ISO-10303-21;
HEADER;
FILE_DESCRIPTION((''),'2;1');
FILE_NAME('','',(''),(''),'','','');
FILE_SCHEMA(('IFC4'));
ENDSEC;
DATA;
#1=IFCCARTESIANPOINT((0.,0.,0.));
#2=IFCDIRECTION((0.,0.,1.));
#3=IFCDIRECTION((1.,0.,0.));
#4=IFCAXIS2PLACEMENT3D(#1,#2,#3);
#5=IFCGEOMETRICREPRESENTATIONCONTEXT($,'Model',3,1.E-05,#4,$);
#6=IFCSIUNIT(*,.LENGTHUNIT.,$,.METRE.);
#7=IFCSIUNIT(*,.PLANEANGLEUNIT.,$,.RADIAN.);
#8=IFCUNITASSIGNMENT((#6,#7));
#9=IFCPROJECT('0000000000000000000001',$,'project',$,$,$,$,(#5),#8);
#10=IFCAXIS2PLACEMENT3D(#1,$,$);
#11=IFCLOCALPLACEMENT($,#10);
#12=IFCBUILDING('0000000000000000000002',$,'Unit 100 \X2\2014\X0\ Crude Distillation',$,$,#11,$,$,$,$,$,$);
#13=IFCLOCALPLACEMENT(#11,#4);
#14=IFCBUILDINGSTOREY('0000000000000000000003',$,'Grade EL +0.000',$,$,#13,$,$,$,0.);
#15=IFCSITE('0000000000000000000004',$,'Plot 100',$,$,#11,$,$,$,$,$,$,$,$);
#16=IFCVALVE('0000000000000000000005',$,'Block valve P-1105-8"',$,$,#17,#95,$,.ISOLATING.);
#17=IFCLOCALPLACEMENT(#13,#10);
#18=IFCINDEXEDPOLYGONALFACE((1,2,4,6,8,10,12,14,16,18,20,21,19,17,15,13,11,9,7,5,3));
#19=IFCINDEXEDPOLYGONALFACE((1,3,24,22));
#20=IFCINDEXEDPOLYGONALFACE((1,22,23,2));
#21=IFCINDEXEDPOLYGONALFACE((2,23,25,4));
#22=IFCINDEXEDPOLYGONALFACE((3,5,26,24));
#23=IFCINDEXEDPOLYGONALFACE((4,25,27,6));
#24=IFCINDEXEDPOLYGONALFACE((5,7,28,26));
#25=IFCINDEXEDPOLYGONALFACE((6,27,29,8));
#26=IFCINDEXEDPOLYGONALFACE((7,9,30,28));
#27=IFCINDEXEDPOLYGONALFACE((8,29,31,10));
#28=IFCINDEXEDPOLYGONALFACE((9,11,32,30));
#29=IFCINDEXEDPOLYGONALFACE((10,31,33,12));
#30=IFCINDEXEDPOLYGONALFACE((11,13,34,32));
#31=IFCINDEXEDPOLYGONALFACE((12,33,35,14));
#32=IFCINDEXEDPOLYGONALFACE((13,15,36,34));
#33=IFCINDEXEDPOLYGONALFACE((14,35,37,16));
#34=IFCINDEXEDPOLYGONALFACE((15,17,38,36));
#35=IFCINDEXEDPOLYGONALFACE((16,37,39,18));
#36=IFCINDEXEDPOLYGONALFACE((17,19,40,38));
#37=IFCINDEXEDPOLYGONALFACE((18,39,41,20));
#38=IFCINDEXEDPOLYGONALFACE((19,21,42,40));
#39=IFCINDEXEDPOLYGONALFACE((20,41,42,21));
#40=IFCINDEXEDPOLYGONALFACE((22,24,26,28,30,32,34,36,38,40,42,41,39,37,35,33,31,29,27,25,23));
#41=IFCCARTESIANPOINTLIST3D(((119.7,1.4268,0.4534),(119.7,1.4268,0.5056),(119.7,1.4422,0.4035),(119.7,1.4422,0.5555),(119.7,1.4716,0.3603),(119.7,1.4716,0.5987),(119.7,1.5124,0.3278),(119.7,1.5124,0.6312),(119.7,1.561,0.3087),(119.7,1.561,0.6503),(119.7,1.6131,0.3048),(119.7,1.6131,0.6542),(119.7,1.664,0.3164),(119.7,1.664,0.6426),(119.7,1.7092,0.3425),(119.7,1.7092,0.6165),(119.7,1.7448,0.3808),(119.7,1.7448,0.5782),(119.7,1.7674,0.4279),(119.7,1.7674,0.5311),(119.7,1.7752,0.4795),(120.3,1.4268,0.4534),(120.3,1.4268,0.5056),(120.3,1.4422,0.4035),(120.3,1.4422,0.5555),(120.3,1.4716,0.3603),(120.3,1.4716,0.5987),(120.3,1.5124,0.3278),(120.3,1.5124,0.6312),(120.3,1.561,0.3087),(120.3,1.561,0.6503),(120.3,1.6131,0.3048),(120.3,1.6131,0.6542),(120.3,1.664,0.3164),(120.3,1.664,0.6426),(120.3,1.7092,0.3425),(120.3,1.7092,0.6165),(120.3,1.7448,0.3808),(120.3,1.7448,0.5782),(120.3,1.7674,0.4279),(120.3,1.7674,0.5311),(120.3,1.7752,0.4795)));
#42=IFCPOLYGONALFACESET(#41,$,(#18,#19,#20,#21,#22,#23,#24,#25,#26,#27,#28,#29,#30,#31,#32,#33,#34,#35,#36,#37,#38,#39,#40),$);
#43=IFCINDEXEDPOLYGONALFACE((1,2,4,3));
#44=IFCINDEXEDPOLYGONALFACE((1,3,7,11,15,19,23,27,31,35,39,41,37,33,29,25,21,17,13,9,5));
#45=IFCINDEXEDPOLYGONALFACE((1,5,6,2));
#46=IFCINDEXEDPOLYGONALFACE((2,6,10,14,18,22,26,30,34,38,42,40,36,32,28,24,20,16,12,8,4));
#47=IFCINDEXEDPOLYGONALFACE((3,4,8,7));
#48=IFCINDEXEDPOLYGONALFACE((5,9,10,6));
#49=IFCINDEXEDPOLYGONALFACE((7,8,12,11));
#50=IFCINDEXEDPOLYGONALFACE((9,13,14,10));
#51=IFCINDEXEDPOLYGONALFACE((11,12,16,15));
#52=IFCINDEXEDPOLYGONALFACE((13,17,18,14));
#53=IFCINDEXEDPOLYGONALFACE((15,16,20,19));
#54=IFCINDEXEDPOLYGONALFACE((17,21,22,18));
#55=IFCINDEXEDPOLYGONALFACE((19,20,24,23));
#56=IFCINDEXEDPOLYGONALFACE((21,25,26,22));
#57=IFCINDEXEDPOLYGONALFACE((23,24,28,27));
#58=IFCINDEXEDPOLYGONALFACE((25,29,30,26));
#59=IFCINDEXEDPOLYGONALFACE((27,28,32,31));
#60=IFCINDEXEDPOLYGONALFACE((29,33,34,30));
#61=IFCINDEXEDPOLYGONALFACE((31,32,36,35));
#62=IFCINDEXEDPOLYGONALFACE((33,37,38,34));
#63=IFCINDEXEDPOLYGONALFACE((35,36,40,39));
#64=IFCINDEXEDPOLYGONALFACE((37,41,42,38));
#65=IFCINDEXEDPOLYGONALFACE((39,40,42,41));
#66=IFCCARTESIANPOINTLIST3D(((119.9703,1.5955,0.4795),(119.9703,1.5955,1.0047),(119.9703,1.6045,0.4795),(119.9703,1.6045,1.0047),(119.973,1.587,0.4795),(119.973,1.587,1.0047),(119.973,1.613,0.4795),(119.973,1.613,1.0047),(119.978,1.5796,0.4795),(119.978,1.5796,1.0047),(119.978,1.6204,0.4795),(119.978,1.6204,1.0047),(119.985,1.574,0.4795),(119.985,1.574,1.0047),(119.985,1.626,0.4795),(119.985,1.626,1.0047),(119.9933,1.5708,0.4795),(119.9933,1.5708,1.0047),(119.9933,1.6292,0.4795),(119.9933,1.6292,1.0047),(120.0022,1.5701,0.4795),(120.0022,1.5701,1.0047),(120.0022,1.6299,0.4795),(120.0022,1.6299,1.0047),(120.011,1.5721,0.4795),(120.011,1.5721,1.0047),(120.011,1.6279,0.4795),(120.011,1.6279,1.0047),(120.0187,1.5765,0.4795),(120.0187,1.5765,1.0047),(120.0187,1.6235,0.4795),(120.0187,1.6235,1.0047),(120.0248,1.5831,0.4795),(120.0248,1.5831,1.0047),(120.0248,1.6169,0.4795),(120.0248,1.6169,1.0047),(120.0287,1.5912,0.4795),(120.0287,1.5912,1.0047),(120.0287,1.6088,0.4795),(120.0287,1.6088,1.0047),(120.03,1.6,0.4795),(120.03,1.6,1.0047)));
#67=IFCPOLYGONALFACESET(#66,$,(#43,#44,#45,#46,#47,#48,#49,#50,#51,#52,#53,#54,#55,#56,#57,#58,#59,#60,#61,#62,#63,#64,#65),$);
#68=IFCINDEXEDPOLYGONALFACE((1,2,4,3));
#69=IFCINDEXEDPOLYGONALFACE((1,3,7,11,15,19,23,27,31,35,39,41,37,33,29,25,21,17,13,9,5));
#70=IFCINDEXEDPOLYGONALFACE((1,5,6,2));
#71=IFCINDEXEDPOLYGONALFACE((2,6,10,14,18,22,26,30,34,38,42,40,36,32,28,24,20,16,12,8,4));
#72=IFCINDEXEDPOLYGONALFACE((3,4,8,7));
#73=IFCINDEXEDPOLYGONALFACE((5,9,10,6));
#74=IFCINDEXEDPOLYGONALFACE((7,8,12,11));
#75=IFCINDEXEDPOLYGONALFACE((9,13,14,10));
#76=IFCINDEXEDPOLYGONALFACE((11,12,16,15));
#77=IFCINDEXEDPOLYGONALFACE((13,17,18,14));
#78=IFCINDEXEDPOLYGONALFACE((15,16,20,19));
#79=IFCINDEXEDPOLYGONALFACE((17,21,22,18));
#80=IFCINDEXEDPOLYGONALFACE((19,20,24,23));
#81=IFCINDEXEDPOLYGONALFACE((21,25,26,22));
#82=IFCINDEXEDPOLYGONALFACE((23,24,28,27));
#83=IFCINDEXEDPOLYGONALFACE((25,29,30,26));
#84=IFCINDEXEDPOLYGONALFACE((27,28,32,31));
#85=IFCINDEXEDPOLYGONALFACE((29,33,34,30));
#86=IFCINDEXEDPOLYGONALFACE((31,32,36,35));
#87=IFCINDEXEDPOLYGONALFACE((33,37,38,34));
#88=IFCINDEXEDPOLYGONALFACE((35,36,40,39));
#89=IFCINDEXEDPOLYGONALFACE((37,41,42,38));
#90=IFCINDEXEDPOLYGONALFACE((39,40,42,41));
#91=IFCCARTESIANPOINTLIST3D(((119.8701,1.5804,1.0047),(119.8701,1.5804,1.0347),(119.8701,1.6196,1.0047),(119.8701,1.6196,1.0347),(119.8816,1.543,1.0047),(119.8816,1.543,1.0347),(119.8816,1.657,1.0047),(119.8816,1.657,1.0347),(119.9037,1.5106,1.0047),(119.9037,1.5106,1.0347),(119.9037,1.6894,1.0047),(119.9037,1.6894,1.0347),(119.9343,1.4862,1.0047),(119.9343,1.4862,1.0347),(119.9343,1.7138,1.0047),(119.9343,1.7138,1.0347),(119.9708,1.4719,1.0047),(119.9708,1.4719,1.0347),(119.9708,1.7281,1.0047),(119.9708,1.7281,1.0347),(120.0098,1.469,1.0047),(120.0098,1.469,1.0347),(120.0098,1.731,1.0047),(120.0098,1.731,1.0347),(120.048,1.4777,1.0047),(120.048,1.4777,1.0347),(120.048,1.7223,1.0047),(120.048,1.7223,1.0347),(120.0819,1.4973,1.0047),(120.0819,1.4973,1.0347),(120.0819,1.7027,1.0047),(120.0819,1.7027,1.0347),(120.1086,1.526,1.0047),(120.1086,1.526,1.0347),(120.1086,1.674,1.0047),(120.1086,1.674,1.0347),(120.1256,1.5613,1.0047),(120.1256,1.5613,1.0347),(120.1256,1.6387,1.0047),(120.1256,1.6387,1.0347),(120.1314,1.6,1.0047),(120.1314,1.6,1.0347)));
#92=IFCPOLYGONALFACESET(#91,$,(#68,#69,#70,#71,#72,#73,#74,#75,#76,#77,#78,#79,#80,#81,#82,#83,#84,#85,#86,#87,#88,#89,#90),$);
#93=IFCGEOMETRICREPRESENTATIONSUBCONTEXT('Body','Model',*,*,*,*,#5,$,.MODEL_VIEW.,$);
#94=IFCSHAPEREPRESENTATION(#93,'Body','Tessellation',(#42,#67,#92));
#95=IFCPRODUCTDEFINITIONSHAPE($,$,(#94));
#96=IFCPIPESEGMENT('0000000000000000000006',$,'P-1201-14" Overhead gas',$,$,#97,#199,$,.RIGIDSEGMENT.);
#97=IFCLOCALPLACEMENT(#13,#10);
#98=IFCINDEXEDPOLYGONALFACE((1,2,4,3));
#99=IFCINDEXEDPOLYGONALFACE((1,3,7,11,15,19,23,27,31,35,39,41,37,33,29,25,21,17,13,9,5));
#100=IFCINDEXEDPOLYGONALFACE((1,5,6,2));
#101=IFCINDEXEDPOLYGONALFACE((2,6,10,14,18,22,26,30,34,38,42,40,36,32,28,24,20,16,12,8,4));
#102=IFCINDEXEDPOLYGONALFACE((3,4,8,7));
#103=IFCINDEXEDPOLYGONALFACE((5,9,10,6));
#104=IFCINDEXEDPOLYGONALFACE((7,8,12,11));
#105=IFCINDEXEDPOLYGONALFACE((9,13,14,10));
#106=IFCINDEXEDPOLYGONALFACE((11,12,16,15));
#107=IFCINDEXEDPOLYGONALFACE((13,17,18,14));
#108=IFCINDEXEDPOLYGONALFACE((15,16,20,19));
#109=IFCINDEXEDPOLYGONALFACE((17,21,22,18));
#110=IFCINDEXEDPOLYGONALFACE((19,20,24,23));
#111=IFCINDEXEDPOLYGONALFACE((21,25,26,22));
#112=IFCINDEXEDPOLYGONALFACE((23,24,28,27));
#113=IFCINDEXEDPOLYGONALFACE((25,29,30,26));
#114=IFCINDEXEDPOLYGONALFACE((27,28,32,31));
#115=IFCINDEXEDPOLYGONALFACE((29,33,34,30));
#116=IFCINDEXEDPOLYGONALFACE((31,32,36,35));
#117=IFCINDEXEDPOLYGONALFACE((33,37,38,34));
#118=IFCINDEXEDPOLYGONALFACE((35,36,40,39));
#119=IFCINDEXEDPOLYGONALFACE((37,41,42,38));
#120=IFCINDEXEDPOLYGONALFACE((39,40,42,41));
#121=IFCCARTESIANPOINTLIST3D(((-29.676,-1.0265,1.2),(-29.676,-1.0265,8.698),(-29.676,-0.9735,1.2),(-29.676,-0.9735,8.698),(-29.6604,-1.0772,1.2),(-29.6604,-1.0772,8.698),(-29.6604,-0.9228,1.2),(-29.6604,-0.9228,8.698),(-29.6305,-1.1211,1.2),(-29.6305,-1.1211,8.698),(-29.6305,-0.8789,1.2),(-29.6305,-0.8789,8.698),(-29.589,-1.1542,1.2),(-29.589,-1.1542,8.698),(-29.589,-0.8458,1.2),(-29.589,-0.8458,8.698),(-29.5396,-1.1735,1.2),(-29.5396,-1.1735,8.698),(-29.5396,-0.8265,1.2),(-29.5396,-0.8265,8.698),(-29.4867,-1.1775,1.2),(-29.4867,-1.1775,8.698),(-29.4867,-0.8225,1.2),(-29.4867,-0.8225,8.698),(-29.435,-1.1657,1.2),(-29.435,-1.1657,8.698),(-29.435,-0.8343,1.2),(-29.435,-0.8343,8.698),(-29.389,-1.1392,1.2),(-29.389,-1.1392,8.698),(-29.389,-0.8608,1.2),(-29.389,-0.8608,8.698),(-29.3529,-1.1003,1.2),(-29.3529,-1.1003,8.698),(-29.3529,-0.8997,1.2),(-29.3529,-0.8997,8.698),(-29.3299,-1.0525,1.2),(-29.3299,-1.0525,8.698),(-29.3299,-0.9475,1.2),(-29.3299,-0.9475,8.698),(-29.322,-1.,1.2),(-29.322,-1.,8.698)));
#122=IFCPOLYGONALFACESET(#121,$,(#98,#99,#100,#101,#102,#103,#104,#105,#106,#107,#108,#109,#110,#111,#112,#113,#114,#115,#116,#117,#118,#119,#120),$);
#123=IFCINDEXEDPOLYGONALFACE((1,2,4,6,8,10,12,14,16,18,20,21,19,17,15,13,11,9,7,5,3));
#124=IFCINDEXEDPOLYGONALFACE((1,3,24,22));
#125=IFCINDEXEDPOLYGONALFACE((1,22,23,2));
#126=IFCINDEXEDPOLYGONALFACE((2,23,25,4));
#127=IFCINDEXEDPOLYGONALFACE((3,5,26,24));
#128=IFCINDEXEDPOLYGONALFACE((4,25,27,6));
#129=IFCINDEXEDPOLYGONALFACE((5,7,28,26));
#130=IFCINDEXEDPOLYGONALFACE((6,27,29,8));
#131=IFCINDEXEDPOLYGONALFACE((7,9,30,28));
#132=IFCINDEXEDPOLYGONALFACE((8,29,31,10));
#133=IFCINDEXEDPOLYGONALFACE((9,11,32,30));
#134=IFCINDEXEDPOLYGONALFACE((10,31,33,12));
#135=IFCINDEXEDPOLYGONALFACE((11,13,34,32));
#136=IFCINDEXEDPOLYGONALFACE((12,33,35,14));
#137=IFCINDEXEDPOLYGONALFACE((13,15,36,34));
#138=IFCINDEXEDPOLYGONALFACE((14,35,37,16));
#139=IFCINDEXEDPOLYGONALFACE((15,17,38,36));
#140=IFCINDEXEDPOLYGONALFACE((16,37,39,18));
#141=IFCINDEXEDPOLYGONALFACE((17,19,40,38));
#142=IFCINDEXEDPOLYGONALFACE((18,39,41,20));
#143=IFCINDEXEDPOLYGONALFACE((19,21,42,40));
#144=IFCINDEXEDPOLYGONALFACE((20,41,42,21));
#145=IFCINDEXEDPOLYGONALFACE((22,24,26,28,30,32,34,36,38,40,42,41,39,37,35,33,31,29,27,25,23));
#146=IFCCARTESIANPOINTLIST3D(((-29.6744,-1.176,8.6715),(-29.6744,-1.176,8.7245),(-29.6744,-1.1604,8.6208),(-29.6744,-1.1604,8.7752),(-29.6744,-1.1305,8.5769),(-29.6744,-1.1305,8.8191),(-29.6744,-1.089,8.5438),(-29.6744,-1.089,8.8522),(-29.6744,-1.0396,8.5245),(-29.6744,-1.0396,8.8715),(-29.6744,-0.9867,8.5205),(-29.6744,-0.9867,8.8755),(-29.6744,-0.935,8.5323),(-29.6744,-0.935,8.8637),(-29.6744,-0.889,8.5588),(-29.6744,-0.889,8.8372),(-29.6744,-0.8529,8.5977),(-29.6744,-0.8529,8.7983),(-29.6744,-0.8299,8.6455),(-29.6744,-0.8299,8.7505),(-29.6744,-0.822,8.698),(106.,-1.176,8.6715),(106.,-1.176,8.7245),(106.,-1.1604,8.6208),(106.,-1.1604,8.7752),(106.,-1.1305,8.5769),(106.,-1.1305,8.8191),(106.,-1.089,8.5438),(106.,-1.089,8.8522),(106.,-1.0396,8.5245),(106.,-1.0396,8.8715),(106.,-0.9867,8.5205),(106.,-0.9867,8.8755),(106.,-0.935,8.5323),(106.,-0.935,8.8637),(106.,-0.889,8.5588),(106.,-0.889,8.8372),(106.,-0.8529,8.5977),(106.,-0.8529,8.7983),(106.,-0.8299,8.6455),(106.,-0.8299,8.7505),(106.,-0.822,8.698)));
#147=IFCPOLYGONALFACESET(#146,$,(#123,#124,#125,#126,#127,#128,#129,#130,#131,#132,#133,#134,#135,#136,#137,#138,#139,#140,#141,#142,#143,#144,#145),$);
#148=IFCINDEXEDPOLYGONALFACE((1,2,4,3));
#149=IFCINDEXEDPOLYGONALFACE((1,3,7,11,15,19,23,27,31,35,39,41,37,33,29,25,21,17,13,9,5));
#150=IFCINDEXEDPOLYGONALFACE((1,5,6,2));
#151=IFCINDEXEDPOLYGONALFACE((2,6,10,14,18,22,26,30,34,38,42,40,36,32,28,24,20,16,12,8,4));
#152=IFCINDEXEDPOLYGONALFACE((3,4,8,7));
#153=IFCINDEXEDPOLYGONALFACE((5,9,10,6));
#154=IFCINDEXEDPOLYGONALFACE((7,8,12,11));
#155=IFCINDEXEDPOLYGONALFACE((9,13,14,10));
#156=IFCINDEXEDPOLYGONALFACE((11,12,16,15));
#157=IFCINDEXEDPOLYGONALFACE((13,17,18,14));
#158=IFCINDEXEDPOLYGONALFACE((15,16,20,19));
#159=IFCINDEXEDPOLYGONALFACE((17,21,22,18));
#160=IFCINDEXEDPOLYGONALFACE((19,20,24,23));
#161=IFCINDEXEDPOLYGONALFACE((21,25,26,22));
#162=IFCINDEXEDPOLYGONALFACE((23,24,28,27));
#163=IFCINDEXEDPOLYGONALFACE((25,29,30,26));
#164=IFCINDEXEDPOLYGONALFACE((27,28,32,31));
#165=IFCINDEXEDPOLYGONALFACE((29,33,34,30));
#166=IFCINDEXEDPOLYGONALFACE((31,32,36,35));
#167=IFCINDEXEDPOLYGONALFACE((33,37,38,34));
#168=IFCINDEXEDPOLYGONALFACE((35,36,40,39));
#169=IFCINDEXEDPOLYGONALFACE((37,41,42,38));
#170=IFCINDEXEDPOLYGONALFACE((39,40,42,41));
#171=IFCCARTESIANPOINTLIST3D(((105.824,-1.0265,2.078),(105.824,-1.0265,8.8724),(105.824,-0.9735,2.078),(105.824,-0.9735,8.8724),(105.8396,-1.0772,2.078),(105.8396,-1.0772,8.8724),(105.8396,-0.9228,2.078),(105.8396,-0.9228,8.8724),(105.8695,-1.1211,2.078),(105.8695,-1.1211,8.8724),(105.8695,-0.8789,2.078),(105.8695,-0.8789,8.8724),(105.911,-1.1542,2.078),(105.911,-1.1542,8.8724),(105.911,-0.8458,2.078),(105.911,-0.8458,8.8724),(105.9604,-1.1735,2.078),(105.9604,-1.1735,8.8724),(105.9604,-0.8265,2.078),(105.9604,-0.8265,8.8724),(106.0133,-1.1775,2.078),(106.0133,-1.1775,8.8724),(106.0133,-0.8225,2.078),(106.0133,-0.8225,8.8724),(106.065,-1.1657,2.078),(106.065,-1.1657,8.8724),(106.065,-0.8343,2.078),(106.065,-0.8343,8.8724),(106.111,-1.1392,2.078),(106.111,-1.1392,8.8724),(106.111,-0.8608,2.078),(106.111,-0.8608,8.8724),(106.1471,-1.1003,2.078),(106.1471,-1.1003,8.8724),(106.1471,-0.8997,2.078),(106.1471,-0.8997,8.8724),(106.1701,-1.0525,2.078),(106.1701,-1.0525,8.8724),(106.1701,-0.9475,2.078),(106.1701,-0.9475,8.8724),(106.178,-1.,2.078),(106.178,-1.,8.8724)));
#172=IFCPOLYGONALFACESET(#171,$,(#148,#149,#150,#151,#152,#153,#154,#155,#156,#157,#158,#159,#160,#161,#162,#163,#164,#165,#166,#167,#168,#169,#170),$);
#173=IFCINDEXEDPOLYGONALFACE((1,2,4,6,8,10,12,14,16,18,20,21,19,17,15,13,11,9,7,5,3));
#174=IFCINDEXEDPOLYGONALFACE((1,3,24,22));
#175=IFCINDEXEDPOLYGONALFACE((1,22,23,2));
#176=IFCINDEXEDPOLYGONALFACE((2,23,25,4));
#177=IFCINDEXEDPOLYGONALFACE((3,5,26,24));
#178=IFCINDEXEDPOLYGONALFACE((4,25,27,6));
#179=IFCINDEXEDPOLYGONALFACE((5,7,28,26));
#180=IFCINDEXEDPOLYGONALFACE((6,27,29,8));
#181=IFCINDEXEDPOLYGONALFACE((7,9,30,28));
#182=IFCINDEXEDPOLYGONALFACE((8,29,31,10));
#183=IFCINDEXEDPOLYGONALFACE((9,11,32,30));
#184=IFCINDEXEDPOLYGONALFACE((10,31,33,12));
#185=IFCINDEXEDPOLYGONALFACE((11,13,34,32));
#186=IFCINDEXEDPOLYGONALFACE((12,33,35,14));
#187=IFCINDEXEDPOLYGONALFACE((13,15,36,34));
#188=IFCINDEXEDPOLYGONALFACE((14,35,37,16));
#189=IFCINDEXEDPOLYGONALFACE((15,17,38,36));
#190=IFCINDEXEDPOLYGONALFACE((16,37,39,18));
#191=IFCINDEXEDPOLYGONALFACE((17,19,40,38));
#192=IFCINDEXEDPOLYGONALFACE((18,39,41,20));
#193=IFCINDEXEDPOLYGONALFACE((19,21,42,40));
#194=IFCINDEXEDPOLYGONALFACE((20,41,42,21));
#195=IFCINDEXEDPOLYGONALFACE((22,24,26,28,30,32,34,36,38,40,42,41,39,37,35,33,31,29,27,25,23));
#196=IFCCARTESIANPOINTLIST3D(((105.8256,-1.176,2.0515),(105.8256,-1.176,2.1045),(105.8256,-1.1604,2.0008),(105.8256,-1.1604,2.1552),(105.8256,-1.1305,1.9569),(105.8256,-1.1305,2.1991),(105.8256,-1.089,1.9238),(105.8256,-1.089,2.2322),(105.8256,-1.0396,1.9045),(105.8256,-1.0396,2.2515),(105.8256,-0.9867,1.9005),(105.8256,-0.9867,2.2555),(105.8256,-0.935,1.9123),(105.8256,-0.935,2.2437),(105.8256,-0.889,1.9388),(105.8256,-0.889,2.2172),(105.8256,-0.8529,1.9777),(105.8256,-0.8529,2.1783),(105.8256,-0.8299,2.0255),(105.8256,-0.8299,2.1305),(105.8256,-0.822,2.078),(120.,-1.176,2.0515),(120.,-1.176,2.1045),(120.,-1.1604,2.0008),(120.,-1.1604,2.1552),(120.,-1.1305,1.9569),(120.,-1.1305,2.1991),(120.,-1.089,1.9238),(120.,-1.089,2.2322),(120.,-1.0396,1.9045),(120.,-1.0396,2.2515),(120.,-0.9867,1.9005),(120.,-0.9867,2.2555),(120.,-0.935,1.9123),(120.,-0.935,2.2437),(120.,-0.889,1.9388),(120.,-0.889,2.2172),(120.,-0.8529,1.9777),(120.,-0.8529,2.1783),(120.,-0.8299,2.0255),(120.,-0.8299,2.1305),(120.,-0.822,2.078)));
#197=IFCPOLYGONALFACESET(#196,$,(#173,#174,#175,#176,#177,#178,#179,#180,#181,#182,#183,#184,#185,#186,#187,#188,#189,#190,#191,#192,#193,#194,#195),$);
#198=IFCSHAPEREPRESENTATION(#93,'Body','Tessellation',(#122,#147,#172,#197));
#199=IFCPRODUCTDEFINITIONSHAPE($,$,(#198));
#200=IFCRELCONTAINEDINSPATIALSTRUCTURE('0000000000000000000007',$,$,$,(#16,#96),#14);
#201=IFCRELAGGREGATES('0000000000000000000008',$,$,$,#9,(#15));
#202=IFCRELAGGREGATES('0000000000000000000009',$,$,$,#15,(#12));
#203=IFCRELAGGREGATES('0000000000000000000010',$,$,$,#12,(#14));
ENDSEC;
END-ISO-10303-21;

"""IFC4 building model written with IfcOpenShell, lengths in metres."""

from ifc_helpers import new_model, si_unit, frame, origin, origin_with_axes, origin_2d, place, context, subcontext, project, spatial, circle, extrude, element, save


model = new_model("IFC4")

# Units and contexts
model_context = context("Model", 3, precision=1e-05, world=origin_with_axes())
body_context = subcontext(model_context, "Body", "Model", "MODEL_VIEW")
ifc_project = project(units=[si_unit("LENGTHUNIT", "METRE"), si_unit("PLANEANGLEUNIT", "RADIAN")], contexts=[model_context])

# Site, building, storey
placement = place(None, origin())
site = spatial("IfcSite", under=ifc_project, at=placement, Name="Plot 100")
building = spatial("IfcBuilding", under=site, at=placement, Name="Unit 100 — Crude Distillation")
storey_placement = place(placement, origin_with_axes())
storey = spatial("IfcBuildingStorey", under=building, at=storey_placement, Name="Grade EL +0.000", Elevation=0.0)

# Valve
valve_1_placement = place(storey_placement, origin_with_axes())
element("IfcValve", 1, at=valve_1_placement, inside=storey, Name="Block valve P-1105-8\"", PredefinedType="ISOLATING", context=body_context, shape_type="SweptSolid", body=[
    extrude(circle(Radius=0.1752, at=origin_2d()), frame((119.7, 1.6, 0.4795), z_axis=(1.0, 0.0, 0.0), x_axis=(0.0, 1.0, 0.0)), (0.0, 0.0, 1.0), 0.6),
    extrude(circle(Radius=0.03, at=origin_2d()), frame((120.0, 1.6, 0.4795), z_axis=(0.0, 0.0, 1.0), x_axis=(1.0, 0.0, 0.0)), (0.0, 0.0, 1.0), 0.5252),
    extrude(circle(Radius=0.1314, at=origin_2d()), frame((120.0, 1.6, 1.0047), z_axis=(0.0, 0.0, 1.0), x_axis=(1.0, 0.0, 0.0)), (0.0, 0.0, 1.0), 0.03),
])

# Pipe segment
pipe_segment_1_placement = place(storey_placement, origin_with_axes())
element("IfcPipeSegment", 2, at=pipe_segment_1_placement, inside=storey, Name="P-1201-14\" Overhead gas", PredefinedType="RIGIDSEGMENT", context=body_context, shape_type="SweptSolid", body=[
    extrude(circle(Radius=0.178, at=origin_2d()), frame((-29.5, -1.0, 1.2), z_axis=(0.0, 0.0, 1.0), x_axis=(1.0, 0.0, 0.0)), (0.0, 0.0, 1.0), 7.498),
    extrude(circle(Radius=0.178, at=origin_2d()), frame((-29.6744, -1.0, 8.698), z_axis=(1.0, 0.0, 0.0), x_axis=(0.0, 1.0, 0.0)), (0.0, 0.0, 1.0), 135.6744),
    extrude(circle(Radius=0.178, at=origin_2d()), frame((106.0, -1.0, 8.8724), z_axis=(0.0, 0.0, -1.0), x_axis=(1.0, 0.0, 0.0)), (0.0, 0.0, 1.0), 6.7944),
    extrude(circle(Radius=0.178, at=origin_2d()), frame((105.8256, -1.0, 2.078), z_axis=(1.0, 0.0, 0.0), x_axis=(0.0, 1.0, 0.0)), (0.0, 0.0, 1.0), 14.1744),
])

save(model, "model.ifc")
